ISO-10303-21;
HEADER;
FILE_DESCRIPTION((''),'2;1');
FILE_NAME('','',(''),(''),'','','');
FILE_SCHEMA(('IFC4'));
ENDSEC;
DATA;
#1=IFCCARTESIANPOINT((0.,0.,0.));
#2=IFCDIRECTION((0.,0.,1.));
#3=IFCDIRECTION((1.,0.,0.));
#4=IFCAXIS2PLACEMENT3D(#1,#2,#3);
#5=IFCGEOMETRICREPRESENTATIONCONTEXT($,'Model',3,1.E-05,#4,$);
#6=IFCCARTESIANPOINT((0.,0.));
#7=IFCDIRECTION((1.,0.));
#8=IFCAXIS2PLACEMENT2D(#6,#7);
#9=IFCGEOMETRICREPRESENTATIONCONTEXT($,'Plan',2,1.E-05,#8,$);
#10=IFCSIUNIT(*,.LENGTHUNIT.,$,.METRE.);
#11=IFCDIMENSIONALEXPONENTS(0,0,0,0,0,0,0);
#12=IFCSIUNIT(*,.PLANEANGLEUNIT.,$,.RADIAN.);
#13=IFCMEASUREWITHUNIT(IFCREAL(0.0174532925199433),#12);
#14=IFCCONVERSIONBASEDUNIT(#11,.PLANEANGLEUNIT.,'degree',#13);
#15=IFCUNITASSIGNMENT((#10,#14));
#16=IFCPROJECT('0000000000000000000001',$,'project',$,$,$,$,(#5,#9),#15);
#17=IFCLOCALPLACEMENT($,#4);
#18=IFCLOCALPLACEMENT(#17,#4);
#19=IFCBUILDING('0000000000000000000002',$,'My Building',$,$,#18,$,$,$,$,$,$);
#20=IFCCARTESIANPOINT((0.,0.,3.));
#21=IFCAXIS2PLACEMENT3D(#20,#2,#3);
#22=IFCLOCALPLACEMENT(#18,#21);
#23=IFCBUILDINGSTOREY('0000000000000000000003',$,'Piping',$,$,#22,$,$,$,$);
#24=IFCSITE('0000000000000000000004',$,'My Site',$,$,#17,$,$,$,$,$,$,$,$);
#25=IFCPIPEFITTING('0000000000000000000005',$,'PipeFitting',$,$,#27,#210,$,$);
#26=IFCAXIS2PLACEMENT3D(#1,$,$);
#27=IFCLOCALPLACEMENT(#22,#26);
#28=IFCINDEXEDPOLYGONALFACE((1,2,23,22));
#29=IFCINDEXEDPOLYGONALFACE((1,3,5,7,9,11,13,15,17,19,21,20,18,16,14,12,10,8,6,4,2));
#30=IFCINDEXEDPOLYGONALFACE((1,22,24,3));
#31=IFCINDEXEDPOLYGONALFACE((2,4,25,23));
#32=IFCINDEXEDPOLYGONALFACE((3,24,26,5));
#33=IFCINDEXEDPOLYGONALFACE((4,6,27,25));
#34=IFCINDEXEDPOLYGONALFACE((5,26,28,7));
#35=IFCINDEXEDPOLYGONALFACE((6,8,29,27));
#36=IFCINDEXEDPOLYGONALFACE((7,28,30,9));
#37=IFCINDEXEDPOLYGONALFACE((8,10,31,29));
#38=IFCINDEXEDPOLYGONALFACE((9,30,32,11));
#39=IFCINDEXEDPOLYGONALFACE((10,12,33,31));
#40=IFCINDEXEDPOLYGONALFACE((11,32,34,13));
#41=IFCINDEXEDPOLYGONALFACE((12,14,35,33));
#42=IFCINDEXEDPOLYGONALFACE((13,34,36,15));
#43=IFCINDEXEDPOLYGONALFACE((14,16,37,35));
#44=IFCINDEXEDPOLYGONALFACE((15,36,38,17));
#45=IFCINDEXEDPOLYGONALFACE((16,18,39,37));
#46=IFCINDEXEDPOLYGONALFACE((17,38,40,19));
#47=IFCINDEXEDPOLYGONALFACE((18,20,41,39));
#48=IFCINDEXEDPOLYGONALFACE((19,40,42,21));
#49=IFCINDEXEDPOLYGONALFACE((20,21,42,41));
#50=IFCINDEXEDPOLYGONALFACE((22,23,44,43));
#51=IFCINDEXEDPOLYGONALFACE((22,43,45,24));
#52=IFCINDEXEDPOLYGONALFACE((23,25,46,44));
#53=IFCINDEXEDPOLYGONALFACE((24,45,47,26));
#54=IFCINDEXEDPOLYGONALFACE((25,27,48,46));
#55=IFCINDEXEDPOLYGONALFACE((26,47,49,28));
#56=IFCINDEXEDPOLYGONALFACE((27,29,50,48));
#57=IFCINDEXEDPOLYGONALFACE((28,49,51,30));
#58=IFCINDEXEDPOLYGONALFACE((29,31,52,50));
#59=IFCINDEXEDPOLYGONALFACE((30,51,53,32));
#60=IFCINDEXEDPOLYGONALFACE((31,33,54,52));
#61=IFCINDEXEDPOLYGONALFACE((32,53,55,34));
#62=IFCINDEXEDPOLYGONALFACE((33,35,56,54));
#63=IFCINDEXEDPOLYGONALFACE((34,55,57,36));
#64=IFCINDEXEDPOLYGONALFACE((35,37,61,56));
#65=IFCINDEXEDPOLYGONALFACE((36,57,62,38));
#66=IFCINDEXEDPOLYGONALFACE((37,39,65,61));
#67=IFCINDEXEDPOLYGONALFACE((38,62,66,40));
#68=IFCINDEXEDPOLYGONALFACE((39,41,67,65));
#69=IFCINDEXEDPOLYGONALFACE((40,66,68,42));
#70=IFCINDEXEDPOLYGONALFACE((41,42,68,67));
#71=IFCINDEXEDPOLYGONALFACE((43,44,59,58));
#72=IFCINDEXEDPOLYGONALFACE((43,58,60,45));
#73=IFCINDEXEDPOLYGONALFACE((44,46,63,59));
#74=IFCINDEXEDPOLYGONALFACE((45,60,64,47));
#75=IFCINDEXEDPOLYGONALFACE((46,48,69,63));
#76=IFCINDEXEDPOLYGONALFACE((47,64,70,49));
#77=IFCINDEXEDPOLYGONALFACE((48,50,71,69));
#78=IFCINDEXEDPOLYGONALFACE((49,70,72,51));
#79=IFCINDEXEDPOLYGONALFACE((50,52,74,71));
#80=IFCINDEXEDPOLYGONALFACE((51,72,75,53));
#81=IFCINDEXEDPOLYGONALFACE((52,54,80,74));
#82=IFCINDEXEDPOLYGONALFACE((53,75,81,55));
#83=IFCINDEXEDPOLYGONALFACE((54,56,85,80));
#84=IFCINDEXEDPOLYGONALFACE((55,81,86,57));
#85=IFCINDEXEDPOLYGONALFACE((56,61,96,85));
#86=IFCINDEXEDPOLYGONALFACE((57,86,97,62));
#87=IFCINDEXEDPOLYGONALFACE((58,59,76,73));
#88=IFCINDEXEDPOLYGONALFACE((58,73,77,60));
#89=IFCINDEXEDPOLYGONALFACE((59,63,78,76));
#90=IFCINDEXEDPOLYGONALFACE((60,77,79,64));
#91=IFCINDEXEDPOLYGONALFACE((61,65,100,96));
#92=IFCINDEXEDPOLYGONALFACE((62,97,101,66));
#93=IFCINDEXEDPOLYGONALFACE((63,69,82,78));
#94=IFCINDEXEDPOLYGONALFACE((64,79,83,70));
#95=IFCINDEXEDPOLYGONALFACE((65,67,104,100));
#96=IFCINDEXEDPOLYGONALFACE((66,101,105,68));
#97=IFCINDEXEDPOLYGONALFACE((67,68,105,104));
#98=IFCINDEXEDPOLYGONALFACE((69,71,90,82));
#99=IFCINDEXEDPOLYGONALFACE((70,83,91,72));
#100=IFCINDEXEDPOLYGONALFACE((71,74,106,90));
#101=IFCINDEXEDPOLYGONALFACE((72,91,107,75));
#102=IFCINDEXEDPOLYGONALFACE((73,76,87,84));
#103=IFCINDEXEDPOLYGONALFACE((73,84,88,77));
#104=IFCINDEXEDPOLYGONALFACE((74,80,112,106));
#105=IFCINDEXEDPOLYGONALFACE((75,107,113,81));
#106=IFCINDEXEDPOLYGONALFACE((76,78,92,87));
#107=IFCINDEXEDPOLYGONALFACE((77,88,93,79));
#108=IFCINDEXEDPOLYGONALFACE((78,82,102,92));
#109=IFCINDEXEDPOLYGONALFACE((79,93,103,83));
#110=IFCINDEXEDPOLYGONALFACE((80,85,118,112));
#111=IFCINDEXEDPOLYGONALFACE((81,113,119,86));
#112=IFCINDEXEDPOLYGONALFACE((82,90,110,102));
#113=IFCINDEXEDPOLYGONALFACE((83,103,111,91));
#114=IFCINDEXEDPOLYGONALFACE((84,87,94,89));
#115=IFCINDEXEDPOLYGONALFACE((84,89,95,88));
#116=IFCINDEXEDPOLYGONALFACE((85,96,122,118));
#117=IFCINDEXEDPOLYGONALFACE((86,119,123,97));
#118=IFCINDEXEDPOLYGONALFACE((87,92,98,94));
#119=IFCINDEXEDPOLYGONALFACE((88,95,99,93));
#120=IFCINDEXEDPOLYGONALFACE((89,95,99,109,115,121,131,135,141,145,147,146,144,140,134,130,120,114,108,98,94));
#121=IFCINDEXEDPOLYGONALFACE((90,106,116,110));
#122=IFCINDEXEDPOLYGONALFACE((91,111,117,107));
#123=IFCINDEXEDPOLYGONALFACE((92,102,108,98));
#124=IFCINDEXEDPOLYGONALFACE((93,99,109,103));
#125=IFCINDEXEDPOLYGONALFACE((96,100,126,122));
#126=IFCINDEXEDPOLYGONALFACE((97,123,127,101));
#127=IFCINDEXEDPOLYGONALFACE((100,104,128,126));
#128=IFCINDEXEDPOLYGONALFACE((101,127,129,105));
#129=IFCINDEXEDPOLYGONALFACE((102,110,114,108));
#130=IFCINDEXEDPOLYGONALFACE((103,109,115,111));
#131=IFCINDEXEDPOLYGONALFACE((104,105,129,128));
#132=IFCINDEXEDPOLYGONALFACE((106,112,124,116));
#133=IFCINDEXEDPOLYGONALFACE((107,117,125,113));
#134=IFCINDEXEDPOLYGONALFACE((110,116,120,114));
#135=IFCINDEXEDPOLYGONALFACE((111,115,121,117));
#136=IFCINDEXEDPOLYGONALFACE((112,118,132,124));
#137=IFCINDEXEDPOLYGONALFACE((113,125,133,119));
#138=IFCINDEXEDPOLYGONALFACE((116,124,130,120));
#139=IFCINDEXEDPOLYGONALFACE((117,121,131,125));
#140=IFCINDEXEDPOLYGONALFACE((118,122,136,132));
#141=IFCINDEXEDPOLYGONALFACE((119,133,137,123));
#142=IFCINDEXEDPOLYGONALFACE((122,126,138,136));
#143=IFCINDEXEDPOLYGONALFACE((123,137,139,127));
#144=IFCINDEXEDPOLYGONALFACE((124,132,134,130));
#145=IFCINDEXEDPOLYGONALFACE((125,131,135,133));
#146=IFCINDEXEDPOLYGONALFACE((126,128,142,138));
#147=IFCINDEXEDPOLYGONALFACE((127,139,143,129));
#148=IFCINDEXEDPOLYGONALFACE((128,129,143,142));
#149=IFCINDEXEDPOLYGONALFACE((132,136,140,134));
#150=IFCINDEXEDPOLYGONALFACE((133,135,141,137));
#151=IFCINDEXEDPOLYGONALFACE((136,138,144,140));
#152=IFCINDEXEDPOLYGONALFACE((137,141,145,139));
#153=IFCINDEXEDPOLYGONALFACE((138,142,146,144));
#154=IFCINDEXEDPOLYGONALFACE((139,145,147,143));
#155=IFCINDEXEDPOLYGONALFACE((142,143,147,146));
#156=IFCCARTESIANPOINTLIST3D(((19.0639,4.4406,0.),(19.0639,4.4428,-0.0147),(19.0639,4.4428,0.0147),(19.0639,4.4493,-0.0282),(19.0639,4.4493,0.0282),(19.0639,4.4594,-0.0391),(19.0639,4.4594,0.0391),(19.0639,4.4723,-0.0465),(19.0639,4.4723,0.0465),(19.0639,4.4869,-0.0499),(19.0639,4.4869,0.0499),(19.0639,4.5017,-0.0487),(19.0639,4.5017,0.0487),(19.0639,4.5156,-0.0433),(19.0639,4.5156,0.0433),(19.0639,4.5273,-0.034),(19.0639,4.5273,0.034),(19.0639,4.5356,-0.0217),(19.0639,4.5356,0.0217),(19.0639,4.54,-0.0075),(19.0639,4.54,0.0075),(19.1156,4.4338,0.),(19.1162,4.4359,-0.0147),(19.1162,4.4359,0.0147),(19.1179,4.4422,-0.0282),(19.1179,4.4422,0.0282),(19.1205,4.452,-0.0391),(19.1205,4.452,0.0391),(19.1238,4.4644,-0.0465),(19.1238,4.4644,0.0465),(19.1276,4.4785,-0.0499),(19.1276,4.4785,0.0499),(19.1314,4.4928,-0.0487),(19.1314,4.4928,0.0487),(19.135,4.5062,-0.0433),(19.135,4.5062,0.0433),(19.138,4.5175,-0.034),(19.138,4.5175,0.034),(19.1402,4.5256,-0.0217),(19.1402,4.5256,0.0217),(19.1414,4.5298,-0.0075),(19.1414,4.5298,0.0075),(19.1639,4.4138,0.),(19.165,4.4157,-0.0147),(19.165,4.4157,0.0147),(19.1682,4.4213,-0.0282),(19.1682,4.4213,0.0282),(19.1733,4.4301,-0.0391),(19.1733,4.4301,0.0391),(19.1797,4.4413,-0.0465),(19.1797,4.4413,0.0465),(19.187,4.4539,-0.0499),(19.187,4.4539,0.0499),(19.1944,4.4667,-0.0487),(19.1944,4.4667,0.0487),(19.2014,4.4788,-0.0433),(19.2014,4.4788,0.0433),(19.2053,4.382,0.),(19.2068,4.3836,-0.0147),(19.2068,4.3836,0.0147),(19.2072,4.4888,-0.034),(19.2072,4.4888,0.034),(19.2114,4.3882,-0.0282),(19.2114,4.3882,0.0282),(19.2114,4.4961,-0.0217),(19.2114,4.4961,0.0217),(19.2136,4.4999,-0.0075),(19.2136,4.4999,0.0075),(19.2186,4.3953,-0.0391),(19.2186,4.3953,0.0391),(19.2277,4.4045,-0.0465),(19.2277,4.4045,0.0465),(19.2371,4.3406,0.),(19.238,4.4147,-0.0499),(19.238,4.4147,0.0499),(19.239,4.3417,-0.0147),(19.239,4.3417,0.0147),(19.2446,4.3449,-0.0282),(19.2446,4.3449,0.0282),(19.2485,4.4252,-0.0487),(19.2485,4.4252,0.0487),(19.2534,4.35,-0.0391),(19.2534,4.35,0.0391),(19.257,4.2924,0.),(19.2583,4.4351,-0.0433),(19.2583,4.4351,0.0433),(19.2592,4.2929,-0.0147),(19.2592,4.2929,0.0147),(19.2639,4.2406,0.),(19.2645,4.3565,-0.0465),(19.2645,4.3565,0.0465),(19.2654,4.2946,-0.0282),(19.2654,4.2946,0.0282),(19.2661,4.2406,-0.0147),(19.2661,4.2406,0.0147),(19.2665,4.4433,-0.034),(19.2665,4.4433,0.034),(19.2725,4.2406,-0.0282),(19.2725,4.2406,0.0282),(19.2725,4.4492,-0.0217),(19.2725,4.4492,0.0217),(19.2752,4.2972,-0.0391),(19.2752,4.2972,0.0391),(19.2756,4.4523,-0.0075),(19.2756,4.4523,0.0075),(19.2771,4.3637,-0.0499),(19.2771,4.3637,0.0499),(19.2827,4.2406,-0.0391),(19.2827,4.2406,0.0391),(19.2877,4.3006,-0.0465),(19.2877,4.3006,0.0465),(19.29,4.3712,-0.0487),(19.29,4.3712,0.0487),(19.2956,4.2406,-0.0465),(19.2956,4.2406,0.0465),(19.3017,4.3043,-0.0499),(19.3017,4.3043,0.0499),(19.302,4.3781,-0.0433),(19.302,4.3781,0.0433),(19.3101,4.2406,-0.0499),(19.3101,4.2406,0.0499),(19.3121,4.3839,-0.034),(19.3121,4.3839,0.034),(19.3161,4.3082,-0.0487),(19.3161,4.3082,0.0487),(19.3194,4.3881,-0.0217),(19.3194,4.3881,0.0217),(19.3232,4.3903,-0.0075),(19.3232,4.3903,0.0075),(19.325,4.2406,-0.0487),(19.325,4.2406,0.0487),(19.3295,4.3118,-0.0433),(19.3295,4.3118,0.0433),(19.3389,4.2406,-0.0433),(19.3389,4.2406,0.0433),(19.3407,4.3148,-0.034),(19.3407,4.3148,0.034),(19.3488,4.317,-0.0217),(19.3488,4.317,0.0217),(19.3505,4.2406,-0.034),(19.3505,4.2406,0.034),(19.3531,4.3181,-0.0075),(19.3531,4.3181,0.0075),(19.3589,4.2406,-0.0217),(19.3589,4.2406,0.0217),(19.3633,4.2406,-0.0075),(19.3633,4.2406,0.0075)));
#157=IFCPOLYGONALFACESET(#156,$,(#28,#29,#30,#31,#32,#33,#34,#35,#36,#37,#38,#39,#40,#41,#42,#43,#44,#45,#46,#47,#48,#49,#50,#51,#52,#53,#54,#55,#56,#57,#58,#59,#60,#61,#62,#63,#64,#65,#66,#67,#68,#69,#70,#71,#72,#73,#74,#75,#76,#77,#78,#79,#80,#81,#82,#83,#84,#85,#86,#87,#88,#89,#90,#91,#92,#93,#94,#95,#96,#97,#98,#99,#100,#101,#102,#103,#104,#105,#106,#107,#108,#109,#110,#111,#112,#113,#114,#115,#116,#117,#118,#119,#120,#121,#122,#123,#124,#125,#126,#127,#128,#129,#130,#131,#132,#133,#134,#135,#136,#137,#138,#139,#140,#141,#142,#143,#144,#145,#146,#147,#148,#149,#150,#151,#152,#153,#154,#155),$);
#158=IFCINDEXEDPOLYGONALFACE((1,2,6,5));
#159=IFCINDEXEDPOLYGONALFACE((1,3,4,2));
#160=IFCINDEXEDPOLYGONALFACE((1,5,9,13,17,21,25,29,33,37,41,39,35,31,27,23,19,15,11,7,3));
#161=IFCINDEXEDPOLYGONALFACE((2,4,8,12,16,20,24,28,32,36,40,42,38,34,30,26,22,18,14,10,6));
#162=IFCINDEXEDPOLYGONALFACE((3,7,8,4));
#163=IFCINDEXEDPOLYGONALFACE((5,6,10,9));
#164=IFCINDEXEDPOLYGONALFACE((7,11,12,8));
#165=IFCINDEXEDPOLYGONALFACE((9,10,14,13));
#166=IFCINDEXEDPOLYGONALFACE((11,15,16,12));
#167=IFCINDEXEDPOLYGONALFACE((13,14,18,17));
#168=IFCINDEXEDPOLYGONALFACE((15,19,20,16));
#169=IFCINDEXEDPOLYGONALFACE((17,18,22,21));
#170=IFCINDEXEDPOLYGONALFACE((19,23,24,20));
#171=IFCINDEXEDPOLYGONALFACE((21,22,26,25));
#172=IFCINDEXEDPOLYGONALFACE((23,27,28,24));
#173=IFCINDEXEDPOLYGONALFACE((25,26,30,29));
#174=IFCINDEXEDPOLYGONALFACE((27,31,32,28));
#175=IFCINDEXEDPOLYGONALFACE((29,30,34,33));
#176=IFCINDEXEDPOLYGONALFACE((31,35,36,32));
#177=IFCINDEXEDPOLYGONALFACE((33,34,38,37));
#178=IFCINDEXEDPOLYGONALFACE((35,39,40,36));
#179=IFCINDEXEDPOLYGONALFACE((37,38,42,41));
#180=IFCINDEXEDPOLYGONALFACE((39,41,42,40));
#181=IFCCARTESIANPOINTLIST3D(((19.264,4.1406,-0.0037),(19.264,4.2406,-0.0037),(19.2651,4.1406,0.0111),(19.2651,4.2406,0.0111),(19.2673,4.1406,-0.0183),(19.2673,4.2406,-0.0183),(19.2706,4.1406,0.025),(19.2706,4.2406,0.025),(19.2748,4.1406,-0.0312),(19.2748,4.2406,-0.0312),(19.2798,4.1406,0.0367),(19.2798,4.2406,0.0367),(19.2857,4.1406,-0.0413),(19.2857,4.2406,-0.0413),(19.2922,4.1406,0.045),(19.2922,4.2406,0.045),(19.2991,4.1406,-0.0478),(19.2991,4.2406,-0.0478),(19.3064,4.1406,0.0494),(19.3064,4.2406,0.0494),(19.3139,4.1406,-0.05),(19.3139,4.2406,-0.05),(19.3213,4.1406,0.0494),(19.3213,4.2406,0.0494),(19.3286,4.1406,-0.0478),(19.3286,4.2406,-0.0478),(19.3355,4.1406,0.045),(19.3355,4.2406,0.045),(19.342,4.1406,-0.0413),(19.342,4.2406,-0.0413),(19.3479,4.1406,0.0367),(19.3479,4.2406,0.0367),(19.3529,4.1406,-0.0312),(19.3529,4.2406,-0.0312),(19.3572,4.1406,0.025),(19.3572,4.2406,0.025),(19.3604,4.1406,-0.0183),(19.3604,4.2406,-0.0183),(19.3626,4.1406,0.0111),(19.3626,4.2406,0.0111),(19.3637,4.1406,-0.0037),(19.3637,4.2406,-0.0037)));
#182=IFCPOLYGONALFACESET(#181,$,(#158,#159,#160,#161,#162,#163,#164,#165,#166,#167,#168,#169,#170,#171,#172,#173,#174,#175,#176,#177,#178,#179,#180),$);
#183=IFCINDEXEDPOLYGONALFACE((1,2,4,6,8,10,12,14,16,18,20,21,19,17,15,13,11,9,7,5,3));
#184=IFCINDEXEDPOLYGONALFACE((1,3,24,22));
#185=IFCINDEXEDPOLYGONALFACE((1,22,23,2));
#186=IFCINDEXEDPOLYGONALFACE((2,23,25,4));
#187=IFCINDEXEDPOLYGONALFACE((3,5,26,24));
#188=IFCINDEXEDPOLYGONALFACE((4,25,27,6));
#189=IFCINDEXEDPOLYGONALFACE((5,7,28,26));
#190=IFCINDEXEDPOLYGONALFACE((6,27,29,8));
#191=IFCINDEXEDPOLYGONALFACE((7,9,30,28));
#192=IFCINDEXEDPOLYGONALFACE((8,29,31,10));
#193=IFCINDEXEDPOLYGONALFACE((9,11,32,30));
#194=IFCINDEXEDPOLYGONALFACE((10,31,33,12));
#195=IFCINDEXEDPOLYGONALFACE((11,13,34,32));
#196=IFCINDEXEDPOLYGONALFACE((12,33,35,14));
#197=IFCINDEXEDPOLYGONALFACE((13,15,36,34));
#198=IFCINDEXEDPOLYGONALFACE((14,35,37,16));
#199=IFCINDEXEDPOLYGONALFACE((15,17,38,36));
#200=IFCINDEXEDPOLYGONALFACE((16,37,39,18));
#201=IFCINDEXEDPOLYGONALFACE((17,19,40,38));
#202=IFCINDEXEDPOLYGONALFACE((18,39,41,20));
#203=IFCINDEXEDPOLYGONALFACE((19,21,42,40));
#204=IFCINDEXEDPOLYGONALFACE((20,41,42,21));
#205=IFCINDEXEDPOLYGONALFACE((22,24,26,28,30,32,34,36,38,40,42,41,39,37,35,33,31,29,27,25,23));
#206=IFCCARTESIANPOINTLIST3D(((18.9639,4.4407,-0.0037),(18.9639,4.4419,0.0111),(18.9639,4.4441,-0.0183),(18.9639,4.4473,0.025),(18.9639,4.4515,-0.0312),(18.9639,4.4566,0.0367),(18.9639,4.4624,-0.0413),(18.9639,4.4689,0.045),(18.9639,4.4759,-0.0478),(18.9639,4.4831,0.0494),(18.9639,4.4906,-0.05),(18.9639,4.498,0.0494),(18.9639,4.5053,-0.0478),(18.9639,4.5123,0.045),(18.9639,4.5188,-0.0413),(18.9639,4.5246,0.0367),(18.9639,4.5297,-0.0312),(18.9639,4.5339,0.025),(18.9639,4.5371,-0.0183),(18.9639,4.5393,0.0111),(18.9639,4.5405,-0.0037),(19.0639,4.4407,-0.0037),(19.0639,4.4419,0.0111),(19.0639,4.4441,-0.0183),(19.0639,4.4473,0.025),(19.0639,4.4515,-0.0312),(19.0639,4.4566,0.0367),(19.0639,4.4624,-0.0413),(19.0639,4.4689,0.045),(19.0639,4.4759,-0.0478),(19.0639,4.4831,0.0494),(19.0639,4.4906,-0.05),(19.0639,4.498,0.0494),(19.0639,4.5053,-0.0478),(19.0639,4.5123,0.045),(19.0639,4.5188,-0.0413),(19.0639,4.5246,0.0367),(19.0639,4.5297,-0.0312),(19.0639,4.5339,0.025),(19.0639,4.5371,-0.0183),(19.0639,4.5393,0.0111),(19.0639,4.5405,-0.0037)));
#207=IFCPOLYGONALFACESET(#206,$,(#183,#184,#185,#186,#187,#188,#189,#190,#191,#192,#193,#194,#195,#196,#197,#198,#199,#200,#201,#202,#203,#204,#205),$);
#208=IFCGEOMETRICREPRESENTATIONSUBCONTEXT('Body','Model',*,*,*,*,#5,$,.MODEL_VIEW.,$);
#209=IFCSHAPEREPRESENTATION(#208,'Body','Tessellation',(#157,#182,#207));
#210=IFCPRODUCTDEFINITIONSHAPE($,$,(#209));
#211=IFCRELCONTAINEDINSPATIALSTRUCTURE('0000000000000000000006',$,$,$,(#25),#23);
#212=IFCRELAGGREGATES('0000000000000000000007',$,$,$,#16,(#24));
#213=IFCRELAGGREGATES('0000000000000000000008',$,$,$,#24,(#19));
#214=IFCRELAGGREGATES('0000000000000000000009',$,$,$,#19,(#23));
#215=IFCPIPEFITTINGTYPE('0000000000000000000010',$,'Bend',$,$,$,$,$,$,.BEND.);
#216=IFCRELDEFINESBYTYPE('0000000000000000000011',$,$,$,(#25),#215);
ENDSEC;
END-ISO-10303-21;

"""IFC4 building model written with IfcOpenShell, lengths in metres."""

from ifc_helpers import new_model, entity, si_unit, converted_unit, frame, origin_with_axes, origin_2d_with_axis, place, context, subcontext, project, spatial, circle, extrude, source, transform, mapped, type_object, type_shapes, element, save


model = new_model("IFC4")

# Units and contexts
model_context = context("Model", 3, precision=1e-05, world=origin_with_axes())
plan_context = context("Plan", 2, precision=1e-05, world=origin_2d_with_axis())
body_context = subcontext(model_context, "Body", "Model", "MODEL_VIEW")
ifc_project = project(units=[si_unit("LENGTHUNIT", "METRE"), converted_unit("PLANEANGLEUNIT", "degree", entity("IfcReal", 0.0174532925199433), si_unit("PLANEANGLEUNIT", "RADIAN"), dimensions=[0, 0, 0, 0, 0, 0, 0])], contexts=[model_context, plan_context])

# Site, building, storey
site_placement = place(None, origin_with_axes())
site = spatial("IfcSite", under=ifc_project, at=site_placement, Name="My Site")
building_placement = place(site_placement, origin_with_axes())
building = spatial("IfcBuilding", under=site, at=building_placement, Name="My Building")
storey_placement = place(building_placement, frame((0.0, 0.0, 3.0), z_axis=(0.0, 0.0, 1.0), x_axis=(1.0, 0.0, 0.0)))
storey = spatial("IfcBuildingStorey", under=building, at=storey_placement, Name="Piping")

# Shared definitions
pipe_fitting_type = type_object("IfcPipeFittingType", Name="Bend", PredefinedType="BEND")
shared_shape = source(origin_with_axes(), body_context, "Body", "SolidModel", [
    entity("IfcSweptDiskSolid", entity("IfcIndexedPolyCurve", entity("IfcCartesianPointList3D", [[0.0, 0.0, -0.1], [0.0, -0.0732, -0.2768], [0.0, -0.25, -0.35]]), [entity("IfcArcIndex", [1, 2, 3])]), 0.05),
    extrude(circle(Radius=0.05), origin_with_axes(), (0.0, 0.0, -1.0), 0.1),
    extrude(circle(Radius=0.05), frame((0.0, -0.25, -0.35), z_axis=(0.0, -1.0, 0.0), x_axis=(1.0, 0.0, 0.0)), (0.0, 0.0, 1.0), 0.1),
])
type_shapes(pipe_fitting_type, [shared_shape])

# Pipe fitting
for number, where, z_axis, x_axis, name in (
    (1, (19.3139, 4.1406, 0.0), (0.0, -1.0, 0.0), (0.0, 0.0, -1.0), "PipeFitting"),
):
    element("IfcPipeFitting", number, at=place(storey_placement, frame(where, z_axis=z_axis, x_axis=x_axis)), inside=storey, type_object=pipe_fitting_type, Name=name, context=body_context, shape_type="MappedRepresentation", body=[
        mapped(shared_shape, transform((0.0, 0.0, 0.0), x_axis=(1.0, 0.0, 0.0), y_axis=(0.0, 1.0, 0.0), z_axis=(0.0, 0.0, 1.0), scale=1.0)),
    ])

save(model, "model.ifc")
